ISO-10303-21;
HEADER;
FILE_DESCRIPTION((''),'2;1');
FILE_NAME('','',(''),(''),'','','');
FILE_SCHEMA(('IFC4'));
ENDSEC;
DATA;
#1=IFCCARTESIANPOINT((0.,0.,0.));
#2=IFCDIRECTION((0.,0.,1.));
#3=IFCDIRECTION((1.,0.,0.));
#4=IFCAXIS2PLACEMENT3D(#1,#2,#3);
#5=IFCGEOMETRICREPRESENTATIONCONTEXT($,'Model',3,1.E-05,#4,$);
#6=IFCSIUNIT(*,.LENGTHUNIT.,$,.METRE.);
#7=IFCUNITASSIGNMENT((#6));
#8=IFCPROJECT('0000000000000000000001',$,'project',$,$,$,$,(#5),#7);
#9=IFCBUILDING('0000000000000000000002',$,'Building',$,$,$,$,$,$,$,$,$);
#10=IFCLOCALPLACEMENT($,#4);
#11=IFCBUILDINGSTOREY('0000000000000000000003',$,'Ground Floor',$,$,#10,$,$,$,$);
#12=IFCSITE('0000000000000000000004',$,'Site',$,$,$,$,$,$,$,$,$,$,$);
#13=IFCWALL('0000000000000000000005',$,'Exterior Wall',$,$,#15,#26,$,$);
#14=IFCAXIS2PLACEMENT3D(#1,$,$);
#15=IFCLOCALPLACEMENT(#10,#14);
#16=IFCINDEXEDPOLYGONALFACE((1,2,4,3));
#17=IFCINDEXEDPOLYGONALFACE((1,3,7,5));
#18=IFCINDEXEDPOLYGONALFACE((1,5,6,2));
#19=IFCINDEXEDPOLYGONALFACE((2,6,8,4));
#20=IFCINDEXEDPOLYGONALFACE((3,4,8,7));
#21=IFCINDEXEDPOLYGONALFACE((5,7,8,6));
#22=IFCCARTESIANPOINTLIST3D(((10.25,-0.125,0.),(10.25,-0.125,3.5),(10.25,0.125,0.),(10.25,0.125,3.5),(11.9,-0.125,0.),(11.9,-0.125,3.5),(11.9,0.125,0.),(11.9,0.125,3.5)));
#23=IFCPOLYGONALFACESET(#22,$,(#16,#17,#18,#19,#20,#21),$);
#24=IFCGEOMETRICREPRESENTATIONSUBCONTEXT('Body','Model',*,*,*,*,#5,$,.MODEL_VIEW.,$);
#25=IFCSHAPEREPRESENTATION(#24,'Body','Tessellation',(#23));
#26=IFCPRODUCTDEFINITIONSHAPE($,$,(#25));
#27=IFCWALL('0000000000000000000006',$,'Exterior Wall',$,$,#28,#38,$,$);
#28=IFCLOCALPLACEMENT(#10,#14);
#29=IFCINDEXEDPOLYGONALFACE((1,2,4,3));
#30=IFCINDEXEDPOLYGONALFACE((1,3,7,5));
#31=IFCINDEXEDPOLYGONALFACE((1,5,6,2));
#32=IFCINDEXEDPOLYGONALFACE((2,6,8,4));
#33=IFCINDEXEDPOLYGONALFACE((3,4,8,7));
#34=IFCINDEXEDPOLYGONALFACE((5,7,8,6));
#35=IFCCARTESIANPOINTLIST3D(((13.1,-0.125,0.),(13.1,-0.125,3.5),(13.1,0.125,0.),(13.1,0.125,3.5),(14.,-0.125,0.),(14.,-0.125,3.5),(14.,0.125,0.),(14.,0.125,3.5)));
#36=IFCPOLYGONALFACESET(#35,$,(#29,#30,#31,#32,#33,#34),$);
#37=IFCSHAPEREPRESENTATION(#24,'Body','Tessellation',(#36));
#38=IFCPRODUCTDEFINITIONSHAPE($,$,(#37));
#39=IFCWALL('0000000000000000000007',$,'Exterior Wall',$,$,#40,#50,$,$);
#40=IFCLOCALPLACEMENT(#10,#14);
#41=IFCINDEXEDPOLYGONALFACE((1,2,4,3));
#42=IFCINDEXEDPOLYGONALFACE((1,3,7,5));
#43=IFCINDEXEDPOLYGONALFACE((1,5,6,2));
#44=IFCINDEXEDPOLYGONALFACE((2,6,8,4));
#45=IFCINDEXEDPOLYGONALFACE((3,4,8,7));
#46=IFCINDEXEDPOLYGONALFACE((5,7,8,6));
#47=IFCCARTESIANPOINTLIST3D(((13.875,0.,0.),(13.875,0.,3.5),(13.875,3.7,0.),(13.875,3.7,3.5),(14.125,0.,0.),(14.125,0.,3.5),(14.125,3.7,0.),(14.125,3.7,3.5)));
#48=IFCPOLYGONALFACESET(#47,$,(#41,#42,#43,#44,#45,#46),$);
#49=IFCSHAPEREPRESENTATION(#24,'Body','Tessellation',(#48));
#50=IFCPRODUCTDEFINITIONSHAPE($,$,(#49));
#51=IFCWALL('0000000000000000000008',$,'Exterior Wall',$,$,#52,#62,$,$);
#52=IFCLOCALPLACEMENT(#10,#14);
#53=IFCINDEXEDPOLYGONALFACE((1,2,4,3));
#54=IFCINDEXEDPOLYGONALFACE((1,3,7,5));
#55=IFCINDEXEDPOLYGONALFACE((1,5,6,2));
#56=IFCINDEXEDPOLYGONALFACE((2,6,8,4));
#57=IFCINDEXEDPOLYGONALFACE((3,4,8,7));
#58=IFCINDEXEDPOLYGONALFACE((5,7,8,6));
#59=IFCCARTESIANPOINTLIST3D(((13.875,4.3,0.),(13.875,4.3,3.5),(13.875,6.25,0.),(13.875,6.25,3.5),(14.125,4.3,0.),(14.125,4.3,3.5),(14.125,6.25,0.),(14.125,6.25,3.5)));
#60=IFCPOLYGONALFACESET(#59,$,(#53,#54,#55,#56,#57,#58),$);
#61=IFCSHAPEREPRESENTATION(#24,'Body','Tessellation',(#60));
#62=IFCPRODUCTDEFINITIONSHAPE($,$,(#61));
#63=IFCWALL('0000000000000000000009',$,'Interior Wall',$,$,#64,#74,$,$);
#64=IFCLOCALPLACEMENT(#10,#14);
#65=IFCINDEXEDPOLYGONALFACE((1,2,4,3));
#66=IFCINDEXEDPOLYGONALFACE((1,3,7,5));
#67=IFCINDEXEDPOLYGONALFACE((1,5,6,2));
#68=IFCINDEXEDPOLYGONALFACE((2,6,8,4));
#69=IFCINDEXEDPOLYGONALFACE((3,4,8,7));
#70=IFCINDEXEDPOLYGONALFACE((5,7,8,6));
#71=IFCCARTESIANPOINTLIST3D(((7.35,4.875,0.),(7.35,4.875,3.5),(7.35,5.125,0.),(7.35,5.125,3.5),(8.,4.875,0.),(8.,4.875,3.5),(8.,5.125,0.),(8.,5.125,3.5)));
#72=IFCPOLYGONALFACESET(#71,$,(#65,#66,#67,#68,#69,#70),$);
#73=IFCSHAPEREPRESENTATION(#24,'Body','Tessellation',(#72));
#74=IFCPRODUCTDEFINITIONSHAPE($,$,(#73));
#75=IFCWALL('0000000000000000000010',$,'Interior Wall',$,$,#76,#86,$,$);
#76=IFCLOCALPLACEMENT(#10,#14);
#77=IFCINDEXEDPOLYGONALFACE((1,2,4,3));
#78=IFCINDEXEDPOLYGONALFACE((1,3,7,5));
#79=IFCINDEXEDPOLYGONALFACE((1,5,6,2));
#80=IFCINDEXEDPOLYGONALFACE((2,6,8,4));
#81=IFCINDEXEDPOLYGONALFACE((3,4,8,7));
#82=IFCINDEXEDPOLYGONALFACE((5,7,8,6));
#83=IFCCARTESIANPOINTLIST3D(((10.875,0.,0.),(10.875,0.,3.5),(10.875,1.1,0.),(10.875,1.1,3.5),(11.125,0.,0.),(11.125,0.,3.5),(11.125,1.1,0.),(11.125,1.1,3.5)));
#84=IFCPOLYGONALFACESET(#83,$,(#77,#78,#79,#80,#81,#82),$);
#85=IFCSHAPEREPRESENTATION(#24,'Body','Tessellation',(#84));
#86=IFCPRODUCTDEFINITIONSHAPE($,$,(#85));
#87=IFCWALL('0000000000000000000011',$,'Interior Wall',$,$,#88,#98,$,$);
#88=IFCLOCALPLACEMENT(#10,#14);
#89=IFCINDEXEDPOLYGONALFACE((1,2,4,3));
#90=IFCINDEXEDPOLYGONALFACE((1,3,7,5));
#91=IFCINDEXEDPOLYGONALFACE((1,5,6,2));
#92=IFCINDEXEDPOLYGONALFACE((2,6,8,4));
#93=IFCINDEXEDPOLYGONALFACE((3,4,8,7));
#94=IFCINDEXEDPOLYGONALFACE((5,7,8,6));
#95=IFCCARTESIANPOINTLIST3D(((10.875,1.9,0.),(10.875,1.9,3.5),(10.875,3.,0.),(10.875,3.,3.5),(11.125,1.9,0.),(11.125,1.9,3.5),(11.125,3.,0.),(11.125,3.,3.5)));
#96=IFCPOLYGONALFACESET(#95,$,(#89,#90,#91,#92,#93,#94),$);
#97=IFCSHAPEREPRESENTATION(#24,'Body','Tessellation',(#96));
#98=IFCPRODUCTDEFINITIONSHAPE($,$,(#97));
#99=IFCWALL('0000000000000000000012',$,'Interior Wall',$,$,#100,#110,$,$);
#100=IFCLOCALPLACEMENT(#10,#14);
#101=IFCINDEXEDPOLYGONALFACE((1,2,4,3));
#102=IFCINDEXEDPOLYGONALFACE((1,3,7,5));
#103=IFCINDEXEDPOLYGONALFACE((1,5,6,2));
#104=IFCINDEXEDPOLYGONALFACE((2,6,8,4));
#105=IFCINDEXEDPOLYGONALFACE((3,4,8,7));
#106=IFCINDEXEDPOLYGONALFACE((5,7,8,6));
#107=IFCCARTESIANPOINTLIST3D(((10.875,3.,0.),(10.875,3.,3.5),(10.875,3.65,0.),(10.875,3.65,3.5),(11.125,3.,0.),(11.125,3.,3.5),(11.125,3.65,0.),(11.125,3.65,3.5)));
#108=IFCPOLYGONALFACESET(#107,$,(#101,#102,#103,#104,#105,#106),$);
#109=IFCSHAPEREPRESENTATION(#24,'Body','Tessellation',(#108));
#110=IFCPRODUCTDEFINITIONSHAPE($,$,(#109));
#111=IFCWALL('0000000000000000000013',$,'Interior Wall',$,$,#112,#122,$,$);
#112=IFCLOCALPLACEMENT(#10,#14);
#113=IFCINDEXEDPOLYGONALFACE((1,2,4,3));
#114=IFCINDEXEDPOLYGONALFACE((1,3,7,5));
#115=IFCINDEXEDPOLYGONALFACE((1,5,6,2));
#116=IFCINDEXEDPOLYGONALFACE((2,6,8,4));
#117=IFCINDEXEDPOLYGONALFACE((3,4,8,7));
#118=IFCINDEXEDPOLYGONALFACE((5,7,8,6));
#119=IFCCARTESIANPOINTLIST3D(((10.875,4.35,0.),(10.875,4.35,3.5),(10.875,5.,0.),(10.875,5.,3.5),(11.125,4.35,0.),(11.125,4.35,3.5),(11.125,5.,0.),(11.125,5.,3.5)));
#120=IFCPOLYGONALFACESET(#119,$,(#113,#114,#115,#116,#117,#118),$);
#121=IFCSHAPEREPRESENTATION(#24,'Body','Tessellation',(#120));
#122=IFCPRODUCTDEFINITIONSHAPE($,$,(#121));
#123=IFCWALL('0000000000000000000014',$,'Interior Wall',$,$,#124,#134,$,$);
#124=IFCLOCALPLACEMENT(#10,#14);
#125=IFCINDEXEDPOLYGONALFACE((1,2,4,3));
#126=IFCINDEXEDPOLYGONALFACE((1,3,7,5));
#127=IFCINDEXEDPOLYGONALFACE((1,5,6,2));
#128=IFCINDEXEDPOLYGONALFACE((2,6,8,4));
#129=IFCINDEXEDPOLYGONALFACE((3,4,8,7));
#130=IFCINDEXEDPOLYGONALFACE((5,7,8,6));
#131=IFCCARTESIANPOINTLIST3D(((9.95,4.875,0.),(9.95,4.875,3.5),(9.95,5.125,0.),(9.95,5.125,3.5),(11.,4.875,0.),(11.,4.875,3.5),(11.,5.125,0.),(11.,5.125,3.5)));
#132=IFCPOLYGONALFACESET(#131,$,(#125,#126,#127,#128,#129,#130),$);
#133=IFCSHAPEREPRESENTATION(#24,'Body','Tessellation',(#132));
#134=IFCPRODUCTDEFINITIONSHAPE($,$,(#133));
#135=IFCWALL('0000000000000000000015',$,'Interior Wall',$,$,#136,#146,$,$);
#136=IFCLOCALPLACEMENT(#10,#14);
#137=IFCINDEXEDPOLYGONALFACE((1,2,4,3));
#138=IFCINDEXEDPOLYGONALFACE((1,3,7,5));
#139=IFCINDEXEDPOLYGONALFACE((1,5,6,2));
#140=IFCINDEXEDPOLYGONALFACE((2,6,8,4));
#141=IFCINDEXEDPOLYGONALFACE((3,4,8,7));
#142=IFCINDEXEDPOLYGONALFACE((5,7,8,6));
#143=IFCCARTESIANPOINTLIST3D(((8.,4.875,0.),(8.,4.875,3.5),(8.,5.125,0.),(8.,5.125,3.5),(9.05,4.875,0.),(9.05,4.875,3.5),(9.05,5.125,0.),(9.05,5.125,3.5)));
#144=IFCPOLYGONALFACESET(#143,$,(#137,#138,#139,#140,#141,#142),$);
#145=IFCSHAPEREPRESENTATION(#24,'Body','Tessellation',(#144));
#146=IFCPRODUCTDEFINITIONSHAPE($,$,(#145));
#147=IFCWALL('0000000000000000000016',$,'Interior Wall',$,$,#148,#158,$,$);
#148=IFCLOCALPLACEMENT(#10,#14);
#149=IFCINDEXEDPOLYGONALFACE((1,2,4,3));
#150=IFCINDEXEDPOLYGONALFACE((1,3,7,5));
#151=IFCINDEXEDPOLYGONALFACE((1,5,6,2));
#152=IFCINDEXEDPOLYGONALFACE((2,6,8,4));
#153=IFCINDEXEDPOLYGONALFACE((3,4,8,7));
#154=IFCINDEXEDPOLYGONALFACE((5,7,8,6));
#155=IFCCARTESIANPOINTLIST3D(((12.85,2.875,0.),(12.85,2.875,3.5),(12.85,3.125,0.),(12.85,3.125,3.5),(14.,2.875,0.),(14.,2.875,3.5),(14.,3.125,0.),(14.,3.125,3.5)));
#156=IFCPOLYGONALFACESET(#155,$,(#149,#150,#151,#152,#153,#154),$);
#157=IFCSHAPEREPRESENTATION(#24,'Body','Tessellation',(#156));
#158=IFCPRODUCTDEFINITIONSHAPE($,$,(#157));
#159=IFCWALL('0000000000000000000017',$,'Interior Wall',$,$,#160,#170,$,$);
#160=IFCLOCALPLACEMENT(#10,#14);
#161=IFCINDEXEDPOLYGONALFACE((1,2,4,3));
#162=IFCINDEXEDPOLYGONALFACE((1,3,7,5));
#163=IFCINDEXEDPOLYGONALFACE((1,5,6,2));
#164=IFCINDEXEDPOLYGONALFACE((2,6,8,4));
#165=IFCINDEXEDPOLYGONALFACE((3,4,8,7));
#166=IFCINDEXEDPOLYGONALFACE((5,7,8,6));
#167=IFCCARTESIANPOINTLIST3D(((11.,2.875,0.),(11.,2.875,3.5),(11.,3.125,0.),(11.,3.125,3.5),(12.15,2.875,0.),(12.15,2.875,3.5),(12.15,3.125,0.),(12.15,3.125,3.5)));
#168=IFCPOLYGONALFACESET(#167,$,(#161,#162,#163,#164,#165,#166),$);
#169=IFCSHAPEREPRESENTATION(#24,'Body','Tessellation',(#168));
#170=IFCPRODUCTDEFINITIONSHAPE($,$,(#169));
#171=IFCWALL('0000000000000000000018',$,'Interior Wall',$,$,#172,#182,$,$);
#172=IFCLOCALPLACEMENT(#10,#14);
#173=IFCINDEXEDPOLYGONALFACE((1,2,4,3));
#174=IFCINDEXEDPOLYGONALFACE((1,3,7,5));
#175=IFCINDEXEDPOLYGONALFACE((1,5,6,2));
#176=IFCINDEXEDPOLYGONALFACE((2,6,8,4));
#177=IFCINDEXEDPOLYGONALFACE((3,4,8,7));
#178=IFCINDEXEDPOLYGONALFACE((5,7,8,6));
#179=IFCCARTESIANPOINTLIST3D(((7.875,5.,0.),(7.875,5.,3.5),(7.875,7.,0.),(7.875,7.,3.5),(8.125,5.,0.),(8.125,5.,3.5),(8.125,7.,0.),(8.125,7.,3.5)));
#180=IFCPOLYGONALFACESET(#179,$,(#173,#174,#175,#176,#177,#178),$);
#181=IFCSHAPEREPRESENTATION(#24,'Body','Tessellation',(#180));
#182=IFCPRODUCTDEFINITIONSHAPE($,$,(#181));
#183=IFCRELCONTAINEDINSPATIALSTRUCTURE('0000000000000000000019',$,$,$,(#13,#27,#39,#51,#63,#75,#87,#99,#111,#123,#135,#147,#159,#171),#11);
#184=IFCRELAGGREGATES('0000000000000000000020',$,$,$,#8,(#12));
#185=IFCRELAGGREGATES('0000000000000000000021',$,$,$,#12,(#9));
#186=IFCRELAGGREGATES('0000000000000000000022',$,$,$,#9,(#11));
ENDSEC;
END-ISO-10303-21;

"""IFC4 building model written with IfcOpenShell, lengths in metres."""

from ifc_helpers import new_model, si_unit, frame, origin_with_axes, place, context, subcontext, project, spatial, indexed_curve, outline, extrude, element, save


model = new_model("IFC4")

# Units and contexts
model_context = context("Model", 3, precision=1e-05, world=origin_with_axes())
body_context = subcontext(model_context, "Body", "Model", "MODEL_VIEW")
ifc_project = project(units=[si_unit("LENGTHUNIT", "METRE")], contexts=[model_context])

# Site, building, storey
site = spatial("IfcSite", under=ifc_project, Name="Site")
building = spatial("IfcBuilding", under=site, Name="Building")
storey_placement = place(None, origin_with_axes())
storey = spatial("IfcBuildingStorey", under=building, at=storey_placement, Name="Ground Floor")

# Walls
wall_1_placement = place(storey_placement, frame((10.25, 0.0, 0.0), z_axis=(0.0, 0.0, 1.0), x_axis=(1.0, 0.0, 0.0)))
element("IfcWall", 1, at=wall_1_placement, inside=storey, Name="Exterior Wall", context=body_context, shape_type="SweptSolid", body=[
    extrude(outline(indexed_curve([(0.0, 0.0), (0.0, 0.25), (1.65, 0.25), (1.65, 0.0), (0.0, 0.0)], self_intersect=False)), frame((0.0, -0.125, 0.0), z_axis=(0.0, 0.0, 1.0), x_axis=(1.0, 0.0, 0.0)), (0.0, 0.0, 1.0), 3.5),
])
wall_2_placement = place(storey_placement, frame((13.1, 0.0, 0.0), z_axis=(0.0, 0.0, 1.0), x_axis=(1.0, 0.0, 0.0)))
element("IfcWall", 2, at=wall_2_placement, inside=storey, Name="Exterior Wall", context=body_context, shape_type="SweptSolid", body=[
    extrude(outline(indexed_curve([(0.0, 0.0), (0.0, 0.25), (0.9, 0.25), (0.9, 0.0), (0.0, 0.0)], self_intersect=False)), frame((0.0, -0.125, 0.0), z_axis=(0.0, 0.0, 1.0), x_axis=(1.0, 0.0, 0.0)), (0.0, 0.0, 1.0), 3.5),
])
wall_3_placement = place(storey_placement, frame((14.0, 0.0, 0.0), z_axis=(0.0, 0.0, 1.0), x_axis=(0.0, 1.0, 0.0)))
element("IfcWall", 3, at=wall_3_placement, inside=storey, Name="Exterior Wall", context=body_context, shape_type="SweptSolid", body=[
    extrude(outline(indexed_curve([(0.0, 0.0), (0.0, 0.25), (3.7, 0.25), (3.7, 0.0), (0.0, 0.0)], self_intersect=False)), frame((0.0, -0.125, 0.0), z_axis=(0.0, 0.0, 1.0), x_axis=(1.0, 0.0, 0.0)), (0.0, 0.0, 1.0), 3.5),
])
wall_4_placement = place(storey_placement, frame((14.0, 4.3, 0.0), z_axis=(0.0, 0.0, 1.0), x_axis=(0.0, 1.0, 0.0)))
element("IfcWall", 4, at=wall_4_placement, inside=storey, Name="Exterior Wall", context=body_context, shape_type="SweptSolid", body=[
    extrude(outline(indexed_curve([(0.0, 0.0), (0.0, 0.25), (1.95, 0.25), (1.95, 0.0), (0.0, 0.0)], self_intersect=False)), frame((0.0, -0.125, 0.0), z_axis=(0.0, 0.0, 1.0), x_axis=(1.0, 0.0, 0.0)), (0.0, 0.0, 1.0), 3.5),
])
wall_5_placement = place(storey_placement, frame((8.0, 5.0, 0.0), z_axis=(0.0, 0.0, 1.0), x_axis=(-1.0, 0.0, 0.0)))
element("IfcWall", 5, at=wall_5_placement, inside=storey, Name="Interior Wall", context=body_context, shape_type="SweptSolid", body=[
    extrude(outline(indexed_curve([(0.0, 0.0), (0.0, 0.25), (0.65, 0.25), (0.65, 0.0), (0.0, 0.0)], self_intersect=False)), frame((0.0, -0.125, 0.0), z_axis=(0.0, 0.0, 1.0), x_axis=(1.0, 0.0, 0.0)), (0.0, 0.0, 1.0), 3.5),
])
for number, where, z_axis, x_axis, name in (
    (6, (11.0, 0.0, 0.0), (0.0, 0.0, 1.0), (0.0, 1.0, 0.0), "Interior Wall"),
    (7, (11.0, 1.9, 0.0), (0.0, 0.0, 1.0), (0.0, 1.0, 0.0), "Interior Wall"),
):
    element("IfcWall", number, at=place(storey_placement, frame(where, z_axis=z_axis, x_axis=x_axis)), inside=storey, Name=name, context=body_context, shape_type="SweptSolid", body=[
        extrude(outline(indexed_curve([(0.0, 0.0), (0.0, 0.25), (1.1, 0.25), (1.1, 0.0), (0.0, 0.0)], self_intersect=False)), frame((0.0, -0.125, 0.0), z_axis=(0.0, 0.0, 1.0), x_axis=(1.0, 0.0, 0.0)), (0.0, 0.0, 1.0), 3.5),
    ])
wall_6_placement = place(storey_placement, frame((11.0, 3.0, 0.0), z_axis=(0.0, 0.0, 1.0), x_axis=(0.0, 1.0, 0.0)))
element("IfcWall", 8, at=wall_6_placement, inside=storey, Name="Interior Wall", context=body_context, shape_type="SweptSolid", body=[
    extrude(outline(indexed_curve([(0.0, 0.0), (0.0, 0.25), (0.65, 0.25), (0.65, 0.0), (0.0, 0.0)], self_intersect=False)), frame((0.0, -0.125, 0.0), z_axis=(0.0, 0.0, 1.0), x_axis=(1.0, 0.0, 0.0)), (0.0, 0.0, 1.0), 3.5),
])
wall_7_placement = place(storey_placement, frame((11.0, 4.35, 0.0), z_axis=(0.0, 0.0, 1.0), x_axis=(0.0, 1.0, 0.0)))
element("IfcWall", 9, at=wall_7_placement, inside=storey, Name="Interior Wall", context=body_context, shape_type="SweptSolid", body=[
    extrude(outline(indexed_curve([(0.0, 0.0), (0.0, 0.25), (0.65, 0.25), (0.65, 0.0), (0.0, 0.0)], self_intersect=False)), frame((0.0, -0.125, 0.0), z_axis=(0.0, 0.0, 1.0), x_axis=(1.0, 0.0, 0.0)), (0.0, 0.0, 1.0), 3.5),
])
for number, where, z_axis, x_axis, name in (
    (10, (11.0, 5.0, 0.0), (0.0, 0.0, 1.0), (-1.0, 0.0, 0.0), "Interior Wall"),
    (11, (9.05, 5.0, 0.0), (0.0, 0.0, 1.0), (-1.0, 0.0, 0.0), "Interior Wall"),
):
    element("IfcWall", number, at=place(storey_placement, frame(where, z_axis=z_axis, x_axis=x_axis)), inside=storey, Name=name, context=body_context, shape_type="SweptSolid", body=[
        extrude(outline(indexed_curve([(0.0, 0.0), (0.0, 0.25), (1.05, 0.25), (1.05, 0.0), (0.0, 0.0)], self_intersect=False)), frame((0.0, -0.125, 0.0), z_axis=(0.0, 0.0, 1.0), x_axis=(1.0, 0.0, 0.0)), (0.0, 0.0, 1.0), 3.5),
    ])
for number, where, z_axis, x_axis, name in (
    (12, (14.0, 3.0, 0.0), (0.0, 0.0, 1.0), (-1.0, 0.0, 0.0), "Interior Wall"),
    (13, (12.15, 3.0, 0.0), (0.0, 0.0, 1.0), (-1.0, 0.0, 0.0), "Interior Wall"),
):
    element("IfcWall", number, at=place(storey_placement, frame(where, z_axis=z_axis, x_axis=x_axis)), inside=storey, Name=name, context=body_context, shape_type="SweptSolid", body=[
        extrude(outline(indexed_curve([(0.0, 0.0), (0.0, 0.25), (1.15, 0.25), (1.15, 0.0), (0.0, 0.0)], self_intersect=False)), frame((0.0, -0.125, 0.0), z_axis=(0.0, 0.0, 1.0), x_axis=(1.0, 0.0, 0.0)), (0.0, 0.0, 1.0), 3.5),
    ])
wall_8_placement = place(storey_placement, frame((8.0, 5.0, 0.0), z_axis=(0.0, 0.0, 1.0), x_axis=(0.0, 1.0, 0.0)))
element("IfcWall", 14, at=wall_8_placement, inside=storey, Name="Interior Wall", context=body_context, shape_type="SweptSolid", body=[
    extrude(outline(indexed_curve([(0.0, 0.0), (0.0, 0.25), (2.0, 0.25), (2.0, 0.0), (0.0, 0.0)], self_intersect=False)), frame((0.0, -0.125, 0.0), z_axis=(0.0, 0.0, 1.0), x_axis=(1.0, 0.0, 0.0)), (0.0, 0.0, 1.0), 3.5),
])

save(model, "model.ifc")
